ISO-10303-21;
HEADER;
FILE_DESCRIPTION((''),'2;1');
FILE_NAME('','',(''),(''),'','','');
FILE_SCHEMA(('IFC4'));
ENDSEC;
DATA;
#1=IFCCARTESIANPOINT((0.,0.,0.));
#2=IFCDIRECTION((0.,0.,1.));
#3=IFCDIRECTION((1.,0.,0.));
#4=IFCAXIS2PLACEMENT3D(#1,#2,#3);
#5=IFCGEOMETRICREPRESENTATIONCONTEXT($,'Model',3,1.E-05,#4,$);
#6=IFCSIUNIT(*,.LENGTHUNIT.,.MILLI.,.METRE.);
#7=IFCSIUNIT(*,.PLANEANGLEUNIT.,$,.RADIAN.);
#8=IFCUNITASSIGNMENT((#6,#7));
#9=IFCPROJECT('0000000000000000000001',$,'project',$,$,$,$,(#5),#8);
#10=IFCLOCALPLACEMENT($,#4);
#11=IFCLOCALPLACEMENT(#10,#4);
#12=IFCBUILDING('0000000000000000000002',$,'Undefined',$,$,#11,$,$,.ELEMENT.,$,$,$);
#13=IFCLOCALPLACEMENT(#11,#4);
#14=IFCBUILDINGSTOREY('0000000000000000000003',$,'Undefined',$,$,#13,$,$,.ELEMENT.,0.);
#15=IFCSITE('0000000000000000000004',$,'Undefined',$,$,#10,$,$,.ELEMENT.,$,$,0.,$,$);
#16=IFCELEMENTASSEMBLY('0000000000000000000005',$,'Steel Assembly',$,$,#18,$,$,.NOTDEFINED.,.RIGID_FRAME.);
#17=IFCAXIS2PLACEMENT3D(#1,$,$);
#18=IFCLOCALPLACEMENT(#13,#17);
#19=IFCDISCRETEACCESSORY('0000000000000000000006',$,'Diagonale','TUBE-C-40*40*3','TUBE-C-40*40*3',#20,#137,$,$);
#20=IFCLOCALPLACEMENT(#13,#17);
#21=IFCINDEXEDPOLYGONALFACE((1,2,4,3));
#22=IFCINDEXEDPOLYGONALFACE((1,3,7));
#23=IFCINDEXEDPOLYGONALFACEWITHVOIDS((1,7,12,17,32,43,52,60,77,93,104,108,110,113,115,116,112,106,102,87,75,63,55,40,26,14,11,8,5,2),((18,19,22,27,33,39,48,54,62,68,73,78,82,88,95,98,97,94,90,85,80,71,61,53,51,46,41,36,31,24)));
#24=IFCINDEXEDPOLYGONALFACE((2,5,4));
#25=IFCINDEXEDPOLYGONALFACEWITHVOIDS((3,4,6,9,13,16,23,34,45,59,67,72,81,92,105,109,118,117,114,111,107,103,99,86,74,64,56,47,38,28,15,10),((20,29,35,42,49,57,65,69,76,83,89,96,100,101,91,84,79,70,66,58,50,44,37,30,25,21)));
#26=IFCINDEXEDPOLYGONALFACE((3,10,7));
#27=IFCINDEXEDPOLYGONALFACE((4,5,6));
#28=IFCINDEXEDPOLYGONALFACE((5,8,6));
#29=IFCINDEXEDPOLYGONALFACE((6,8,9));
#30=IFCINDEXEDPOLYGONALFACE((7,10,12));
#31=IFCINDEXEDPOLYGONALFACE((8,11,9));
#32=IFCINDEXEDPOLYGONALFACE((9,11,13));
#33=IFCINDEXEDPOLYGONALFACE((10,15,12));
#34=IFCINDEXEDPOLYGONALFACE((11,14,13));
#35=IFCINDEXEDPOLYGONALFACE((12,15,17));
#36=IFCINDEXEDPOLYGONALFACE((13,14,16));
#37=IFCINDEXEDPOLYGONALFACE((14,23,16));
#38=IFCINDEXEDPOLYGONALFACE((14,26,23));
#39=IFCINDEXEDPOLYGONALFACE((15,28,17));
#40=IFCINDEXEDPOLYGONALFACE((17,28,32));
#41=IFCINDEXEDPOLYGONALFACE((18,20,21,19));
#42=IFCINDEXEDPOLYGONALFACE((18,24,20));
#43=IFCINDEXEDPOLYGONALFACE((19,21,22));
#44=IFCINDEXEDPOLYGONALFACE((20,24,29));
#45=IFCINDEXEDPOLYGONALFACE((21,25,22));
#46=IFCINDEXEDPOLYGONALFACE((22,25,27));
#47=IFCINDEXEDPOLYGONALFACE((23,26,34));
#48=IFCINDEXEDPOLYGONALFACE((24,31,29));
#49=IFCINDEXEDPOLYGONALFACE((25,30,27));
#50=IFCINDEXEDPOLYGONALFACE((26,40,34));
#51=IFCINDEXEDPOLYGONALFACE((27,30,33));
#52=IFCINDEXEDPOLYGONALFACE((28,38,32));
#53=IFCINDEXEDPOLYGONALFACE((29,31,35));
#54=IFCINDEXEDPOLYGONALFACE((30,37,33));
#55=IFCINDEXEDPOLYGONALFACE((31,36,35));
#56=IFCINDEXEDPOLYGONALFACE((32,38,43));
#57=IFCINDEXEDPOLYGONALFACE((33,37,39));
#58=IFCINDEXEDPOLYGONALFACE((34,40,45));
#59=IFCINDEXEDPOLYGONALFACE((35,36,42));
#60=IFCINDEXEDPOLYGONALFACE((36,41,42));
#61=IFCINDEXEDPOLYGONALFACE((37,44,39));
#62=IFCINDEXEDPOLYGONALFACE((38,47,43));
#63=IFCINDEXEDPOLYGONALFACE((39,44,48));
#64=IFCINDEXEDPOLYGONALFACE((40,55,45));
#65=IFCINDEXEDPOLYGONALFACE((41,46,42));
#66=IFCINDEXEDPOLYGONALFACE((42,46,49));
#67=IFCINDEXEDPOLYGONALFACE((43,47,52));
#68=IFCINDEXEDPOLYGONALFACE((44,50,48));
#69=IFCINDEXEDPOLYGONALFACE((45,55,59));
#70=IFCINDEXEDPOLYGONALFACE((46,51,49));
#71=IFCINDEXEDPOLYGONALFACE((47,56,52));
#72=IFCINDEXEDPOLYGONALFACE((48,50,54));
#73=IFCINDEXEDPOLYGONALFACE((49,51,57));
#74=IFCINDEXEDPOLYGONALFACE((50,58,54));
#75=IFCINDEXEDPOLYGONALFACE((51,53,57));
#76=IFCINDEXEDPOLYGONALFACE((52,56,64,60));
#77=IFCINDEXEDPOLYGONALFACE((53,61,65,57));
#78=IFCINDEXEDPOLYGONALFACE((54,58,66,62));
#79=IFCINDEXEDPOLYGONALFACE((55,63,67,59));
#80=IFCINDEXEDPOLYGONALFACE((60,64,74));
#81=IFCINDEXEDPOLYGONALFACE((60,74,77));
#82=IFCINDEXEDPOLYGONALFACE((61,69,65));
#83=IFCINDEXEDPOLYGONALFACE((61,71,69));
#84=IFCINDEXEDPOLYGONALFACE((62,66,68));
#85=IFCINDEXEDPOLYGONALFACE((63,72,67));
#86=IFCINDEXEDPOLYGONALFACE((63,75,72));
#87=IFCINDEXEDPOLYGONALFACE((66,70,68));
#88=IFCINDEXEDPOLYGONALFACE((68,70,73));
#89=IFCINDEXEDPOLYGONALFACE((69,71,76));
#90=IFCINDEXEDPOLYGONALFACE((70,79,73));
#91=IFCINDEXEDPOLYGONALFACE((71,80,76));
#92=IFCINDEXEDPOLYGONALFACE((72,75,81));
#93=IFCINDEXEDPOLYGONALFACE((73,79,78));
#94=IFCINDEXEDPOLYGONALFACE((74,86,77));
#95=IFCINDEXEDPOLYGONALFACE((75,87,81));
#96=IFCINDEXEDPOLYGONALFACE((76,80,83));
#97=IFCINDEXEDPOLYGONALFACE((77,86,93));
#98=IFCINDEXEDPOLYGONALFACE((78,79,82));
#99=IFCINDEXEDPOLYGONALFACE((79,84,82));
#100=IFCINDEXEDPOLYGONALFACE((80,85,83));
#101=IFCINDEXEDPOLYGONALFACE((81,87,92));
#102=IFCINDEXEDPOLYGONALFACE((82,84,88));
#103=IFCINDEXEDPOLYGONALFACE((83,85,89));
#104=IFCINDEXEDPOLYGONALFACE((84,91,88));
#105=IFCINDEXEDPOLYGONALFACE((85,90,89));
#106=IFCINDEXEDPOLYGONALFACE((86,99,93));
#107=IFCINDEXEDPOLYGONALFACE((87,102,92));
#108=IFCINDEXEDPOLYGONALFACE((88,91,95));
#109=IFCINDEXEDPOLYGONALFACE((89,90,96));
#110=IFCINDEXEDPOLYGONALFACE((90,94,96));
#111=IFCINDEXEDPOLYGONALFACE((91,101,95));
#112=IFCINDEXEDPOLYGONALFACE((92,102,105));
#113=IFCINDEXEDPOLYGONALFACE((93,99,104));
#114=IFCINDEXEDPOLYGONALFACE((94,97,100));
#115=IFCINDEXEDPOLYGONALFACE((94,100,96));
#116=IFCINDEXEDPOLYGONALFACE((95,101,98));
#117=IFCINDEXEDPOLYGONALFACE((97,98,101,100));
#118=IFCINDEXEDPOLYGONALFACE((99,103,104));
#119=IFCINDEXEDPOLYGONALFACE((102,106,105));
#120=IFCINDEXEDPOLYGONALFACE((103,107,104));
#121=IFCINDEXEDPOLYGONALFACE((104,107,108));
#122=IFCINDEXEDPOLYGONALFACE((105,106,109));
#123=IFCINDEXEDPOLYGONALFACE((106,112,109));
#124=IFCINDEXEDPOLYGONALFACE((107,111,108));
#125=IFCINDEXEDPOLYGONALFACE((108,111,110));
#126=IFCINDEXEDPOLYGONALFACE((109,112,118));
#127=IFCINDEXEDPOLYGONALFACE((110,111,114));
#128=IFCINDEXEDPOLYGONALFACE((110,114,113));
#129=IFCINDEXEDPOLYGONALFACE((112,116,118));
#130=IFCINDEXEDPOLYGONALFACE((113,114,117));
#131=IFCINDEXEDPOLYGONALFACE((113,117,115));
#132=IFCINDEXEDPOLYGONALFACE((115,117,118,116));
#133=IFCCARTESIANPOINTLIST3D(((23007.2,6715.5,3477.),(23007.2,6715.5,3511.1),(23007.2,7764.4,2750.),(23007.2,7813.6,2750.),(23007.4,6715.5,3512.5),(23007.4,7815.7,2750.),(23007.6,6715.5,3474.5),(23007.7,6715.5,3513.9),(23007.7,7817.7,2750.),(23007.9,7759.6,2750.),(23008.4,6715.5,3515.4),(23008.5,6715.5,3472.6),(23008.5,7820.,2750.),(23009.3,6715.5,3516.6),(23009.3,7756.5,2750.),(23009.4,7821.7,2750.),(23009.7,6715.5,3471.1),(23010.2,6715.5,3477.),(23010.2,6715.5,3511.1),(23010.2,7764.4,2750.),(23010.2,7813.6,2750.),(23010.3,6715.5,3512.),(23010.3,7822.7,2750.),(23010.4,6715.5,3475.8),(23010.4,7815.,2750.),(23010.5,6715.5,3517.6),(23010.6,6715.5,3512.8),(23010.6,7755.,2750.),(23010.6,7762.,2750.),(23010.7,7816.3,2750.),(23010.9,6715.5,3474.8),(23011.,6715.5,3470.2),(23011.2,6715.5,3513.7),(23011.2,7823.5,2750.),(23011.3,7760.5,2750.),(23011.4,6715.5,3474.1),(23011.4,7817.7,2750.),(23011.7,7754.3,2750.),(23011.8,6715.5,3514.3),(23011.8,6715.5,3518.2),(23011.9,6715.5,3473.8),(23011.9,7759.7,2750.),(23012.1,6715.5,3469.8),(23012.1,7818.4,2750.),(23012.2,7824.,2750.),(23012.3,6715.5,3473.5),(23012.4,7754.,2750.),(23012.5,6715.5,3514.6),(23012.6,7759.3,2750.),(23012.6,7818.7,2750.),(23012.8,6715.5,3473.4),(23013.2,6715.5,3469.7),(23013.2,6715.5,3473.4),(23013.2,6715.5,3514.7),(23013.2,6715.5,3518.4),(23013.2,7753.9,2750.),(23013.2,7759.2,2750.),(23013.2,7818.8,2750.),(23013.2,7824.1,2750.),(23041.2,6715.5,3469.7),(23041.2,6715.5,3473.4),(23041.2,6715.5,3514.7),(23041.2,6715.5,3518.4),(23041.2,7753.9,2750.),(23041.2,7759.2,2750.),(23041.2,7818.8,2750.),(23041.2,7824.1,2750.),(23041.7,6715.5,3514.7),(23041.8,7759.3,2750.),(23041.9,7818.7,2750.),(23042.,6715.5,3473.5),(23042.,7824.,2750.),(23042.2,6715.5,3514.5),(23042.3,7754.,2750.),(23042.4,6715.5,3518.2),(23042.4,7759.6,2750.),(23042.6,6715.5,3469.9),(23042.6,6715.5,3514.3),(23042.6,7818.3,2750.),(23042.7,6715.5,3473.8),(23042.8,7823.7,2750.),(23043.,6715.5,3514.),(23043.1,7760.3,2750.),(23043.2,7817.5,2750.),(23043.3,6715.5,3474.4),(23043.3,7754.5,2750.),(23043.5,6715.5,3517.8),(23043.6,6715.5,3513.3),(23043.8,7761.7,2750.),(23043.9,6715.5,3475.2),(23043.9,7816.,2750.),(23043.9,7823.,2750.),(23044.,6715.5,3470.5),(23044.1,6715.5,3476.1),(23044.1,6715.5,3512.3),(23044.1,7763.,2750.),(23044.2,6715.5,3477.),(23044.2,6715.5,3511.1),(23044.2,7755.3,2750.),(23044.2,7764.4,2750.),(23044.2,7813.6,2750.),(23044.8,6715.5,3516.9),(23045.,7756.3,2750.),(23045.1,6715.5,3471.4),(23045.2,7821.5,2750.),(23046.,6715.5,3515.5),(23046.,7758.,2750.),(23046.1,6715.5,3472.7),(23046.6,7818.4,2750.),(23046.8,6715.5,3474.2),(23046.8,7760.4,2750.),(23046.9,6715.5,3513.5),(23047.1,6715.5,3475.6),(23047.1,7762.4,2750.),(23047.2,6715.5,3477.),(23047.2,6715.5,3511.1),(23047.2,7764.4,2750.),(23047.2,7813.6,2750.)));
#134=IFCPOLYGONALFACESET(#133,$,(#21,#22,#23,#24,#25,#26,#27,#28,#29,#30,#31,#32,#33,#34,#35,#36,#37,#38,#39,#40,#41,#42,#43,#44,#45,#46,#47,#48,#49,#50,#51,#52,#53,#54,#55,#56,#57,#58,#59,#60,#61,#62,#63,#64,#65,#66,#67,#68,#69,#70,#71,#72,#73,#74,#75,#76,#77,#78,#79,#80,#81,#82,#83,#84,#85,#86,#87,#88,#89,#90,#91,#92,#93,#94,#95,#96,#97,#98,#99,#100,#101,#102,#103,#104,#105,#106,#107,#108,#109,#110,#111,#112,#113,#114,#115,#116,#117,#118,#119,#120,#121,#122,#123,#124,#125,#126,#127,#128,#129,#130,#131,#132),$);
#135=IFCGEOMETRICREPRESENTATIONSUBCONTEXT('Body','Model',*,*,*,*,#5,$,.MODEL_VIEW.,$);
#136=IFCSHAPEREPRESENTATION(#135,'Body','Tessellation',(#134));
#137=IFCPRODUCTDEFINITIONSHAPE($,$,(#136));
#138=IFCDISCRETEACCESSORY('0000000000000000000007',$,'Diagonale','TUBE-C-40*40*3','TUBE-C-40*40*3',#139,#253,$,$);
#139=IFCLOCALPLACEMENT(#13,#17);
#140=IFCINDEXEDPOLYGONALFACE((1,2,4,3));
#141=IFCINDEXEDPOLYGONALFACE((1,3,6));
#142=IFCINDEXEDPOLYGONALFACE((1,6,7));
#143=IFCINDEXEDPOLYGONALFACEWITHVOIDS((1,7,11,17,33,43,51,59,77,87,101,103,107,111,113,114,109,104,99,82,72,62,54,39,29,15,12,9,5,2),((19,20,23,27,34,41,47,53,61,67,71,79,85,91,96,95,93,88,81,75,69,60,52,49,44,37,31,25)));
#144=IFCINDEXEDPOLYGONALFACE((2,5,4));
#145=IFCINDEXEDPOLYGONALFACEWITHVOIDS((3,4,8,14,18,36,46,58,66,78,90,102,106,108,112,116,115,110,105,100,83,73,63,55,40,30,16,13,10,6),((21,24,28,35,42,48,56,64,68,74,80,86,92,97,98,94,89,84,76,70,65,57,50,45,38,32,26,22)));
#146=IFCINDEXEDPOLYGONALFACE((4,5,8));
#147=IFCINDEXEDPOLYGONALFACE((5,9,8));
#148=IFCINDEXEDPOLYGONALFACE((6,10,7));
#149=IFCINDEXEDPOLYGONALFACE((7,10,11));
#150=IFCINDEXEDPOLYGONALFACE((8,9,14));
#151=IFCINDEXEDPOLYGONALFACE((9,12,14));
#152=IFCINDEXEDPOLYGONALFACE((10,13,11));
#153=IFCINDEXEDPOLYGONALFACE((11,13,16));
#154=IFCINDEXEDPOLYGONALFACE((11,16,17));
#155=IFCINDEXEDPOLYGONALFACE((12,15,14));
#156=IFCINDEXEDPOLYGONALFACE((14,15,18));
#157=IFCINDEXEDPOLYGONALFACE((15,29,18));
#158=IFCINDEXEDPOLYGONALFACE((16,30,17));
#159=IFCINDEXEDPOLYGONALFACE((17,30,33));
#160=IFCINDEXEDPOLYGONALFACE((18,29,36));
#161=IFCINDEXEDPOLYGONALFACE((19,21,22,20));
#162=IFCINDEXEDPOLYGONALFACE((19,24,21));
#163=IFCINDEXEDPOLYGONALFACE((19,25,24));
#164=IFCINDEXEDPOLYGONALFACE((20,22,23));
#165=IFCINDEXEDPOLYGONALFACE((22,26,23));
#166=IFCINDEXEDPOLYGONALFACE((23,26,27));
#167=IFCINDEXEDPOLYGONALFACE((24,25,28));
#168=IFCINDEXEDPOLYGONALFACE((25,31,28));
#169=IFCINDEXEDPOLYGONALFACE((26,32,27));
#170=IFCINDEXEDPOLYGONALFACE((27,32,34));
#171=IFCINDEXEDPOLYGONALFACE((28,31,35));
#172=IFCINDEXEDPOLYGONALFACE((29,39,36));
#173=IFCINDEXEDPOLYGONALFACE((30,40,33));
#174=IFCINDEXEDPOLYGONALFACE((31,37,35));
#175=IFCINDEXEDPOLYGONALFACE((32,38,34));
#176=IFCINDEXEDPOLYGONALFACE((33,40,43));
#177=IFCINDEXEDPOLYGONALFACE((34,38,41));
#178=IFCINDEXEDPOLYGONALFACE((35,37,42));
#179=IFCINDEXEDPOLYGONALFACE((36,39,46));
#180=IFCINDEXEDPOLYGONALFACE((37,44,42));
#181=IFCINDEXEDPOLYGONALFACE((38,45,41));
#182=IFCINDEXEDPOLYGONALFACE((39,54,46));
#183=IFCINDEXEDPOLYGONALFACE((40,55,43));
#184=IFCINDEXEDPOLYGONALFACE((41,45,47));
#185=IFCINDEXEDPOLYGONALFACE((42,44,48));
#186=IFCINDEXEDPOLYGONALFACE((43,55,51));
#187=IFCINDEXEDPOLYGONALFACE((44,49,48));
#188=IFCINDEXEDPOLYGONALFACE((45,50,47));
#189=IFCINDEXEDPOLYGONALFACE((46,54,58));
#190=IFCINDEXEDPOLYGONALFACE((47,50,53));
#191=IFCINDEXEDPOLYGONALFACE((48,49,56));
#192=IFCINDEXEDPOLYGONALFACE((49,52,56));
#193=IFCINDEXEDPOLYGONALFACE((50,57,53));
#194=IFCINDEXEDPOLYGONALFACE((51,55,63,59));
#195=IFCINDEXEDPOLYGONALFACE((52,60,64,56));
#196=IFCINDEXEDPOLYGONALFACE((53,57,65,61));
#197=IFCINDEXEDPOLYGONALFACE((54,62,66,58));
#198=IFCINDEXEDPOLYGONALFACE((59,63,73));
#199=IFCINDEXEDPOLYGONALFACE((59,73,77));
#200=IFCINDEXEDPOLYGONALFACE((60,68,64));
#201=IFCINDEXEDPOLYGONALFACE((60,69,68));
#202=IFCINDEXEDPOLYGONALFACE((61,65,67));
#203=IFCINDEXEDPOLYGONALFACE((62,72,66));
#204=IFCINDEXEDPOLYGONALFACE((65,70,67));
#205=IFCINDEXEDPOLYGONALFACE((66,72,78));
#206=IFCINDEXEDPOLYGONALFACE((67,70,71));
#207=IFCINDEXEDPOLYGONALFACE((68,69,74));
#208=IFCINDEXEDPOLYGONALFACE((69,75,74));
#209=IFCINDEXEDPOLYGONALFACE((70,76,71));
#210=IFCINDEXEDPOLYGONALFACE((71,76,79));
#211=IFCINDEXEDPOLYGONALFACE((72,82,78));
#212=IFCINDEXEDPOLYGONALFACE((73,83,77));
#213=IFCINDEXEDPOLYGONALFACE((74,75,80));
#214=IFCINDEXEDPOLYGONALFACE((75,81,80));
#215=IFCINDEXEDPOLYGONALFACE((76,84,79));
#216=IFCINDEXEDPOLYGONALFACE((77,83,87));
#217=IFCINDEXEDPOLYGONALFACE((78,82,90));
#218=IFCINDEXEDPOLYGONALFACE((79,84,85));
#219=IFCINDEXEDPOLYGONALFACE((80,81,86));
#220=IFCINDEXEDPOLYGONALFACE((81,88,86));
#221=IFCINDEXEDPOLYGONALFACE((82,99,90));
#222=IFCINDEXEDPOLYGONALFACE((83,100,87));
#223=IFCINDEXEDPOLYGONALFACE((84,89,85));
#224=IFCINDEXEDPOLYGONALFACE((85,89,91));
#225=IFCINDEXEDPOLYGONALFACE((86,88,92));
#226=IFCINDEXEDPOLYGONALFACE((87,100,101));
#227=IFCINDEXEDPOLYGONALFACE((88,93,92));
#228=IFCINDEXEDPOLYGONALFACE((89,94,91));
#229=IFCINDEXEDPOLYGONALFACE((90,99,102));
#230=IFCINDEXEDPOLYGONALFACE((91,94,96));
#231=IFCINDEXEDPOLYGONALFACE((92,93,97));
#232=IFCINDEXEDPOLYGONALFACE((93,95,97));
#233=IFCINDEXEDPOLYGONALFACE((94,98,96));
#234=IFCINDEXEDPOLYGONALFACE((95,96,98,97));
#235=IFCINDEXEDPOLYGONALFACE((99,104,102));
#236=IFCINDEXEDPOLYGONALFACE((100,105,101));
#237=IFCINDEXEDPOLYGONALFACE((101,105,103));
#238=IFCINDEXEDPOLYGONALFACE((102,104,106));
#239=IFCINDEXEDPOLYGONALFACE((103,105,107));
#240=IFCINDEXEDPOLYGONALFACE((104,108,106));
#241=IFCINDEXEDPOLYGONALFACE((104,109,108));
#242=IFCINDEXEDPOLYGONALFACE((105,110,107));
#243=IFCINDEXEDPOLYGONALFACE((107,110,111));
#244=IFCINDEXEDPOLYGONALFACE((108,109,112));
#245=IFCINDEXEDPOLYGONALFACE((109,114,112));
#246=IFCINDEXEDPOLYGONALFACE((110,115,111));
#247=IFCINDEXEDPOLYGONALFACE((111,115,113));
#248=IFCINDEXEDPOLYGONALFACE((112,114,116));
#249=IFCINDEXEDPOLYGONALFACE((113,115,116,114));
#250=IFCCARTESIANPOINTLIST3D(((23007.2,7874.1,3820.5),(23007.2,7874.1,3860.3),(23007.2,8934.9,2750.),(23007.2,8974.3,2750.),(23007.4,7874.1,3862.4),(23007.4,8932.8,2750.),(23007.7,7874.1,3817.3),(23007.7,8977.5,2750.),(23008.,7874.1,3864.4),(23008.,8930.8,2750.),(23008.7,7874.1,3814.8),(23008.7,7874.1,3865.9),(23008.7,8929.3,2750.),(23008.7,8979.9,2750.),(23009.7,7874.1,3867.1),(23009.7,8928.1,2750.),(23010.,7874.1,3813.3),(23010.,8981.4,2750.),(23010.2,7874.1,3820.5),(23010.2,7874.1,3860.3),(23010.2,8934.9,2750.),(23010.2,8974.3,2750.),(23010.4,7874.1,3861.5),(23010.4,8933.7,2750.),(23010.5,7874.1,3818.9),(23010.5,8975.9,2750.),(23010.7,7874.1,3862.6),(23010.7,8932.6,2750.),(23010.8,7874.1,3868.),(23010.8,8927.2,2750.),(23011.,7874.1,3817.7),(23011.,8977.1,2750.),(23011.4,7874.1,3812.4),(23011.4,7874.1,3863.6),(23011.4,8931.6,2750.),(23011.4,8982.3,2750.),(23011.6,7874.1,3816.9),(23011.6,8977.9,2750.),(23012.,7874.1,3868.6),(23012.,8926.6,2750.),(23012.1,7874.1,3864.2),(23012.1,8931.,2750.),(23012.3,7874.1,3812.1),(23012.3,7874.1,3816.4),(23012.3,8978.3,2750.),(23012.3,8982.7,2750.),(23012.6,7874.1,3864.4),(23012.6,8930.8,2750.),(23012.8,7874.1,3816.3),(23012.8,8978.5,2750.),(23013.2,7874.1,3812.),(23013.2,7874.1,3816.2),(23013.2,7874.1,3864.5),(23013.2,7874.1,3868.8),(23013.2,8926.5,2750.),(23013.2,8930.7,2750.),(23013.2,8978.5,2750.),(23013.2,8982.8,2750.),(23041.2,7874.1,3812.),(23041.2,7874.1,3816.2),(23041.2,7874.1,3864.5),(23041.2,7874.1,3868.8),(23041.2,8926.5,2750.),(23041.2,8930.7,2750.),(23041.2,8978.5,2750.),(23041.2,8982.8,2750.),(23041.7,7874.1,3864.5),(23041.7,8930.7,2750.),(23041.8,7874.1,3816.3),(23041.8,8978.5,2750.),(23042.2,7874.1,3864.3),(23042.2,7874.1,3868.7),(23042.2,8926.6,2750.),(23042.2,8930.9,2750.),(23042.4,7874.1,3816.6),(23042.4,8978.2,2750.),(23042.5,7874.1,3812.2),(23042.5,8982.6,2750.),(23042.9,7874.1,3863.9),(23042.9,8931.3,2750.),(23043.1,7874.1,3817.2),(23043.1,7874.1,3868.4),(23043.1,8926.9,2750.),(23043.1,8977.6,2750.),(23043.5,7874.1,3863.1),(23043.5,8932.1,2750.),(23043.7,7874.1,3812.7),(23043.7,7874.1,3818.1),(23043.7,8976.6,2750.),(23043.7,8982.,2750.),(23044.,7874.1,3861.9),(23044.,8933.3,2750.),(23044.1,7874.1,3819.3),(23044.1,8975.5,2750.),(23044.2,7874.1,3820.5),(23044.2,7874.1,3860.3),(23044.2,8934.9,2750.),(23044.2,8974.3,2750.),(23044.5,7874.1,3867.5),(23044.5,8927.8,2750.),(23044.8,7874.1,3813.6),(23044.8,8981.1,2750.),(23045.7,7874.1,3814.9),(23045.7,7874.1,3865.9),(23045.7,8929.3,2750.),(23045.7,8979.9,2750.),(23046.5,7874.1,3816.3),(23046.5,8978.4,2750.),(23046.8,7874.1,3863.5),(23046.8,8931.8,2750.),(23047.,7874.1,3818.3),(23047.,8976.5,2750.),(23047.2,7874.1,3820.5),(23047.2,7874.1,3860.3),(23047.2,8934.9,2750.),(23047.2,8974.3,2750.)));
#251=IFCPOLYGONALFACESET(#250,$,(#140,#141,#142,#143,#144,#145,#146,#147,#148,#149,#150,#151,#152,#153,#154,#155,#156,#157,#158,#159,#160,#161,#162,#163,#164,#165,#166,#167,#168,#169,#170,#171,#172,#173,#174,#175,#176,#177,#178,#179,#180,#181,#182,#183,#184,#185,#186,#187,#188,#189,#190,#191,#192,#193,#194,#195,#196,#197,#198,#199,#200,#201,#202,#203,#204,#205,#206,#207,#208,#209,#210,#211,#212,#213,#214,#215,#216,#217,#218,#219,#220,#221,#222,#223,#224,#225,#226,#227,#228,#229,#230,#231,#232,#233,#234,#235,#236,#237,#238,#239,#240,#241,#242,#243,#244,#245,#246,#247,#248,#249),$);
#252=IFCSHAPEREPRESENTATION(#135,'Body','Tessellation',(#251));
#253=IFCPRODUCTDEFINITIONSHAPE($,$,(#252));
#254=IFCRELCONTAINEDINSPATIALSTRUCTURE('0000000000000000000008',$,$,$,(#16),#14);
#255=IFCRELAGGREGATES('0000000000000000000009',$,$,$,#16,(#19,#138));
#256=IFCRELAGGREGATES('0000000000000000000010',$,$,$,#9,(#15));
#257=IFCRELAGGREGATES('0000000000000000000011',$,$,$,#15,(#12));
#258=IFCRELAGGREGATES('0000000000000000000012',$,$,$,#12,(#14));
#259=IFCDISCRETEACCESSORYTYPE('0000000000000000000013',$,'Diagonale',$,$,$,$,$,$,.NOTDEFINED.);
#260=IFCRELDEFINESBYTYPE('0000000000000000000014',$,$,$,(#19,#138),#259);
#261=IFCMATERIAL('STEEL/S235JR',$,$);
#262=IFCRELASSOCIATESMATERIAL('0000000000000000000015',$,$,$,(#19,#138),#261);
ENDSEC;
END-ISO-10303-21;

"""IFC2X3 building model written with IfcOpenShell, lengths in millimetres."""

from ifc_helpers import new_model, si_unit, frame, origin_with_axes, origin_2d_with_axis, place, context, subcontext, project, spatial, hollow_rectangle, extrude, clip, halfspace, material, type_object, element, aggregate, save


model = new_model("IFC2X3")

# Units and contexts
model_context = context("Model", 3, precision=1e-05, world=origin_with_axes())
body_context = subcontext(model_context, "Body", "Model", "MODEL_VIEW")
ifc_project = project(units=[si_unit("LENGTHUNIT", "METRE", prefix="MILLI"), si_unit("PLANEANGLEUNIT", "RADIAN")], contexts=[model_context])

# Site, building, storey
site_placement = place(None, origin_with_axes())
site = spatial("IfcSite", under=ifc_project, at=site_placement, Name="Undefined", CompositionType="ELEMENT", RefElevation=0.0)
building_placement = place(site_placement, origin_with_axes())
building = spatial("IfcBuilding", under=site, at=building_placement, Name="Undefined", CompositionType="ELEMENT")
storey_placement = place(building_placement, origin_with_axes())
storey = spatial("IfcBuildingStorey", under=building, at=storey_placement, Name="Undefined", CompositionType="ELEMENT", Elevation=0.0)

# Element assembly, discrete accessories
ifc_material_1 = material(Name="STEEL/S235JR")
assembly_1_placement = place(storey_placement, origin_with_axes())
assembly_1 = element("IfcElementAssembly", 1, at=assembly_1_placement, inside=storey, Name="Steel Assembly", AssemblyPlace="NOTDEFINED", PredefinedType="RIGID_FRAME")
discrete_accessory_type_1 = type_object("IfcDiscreteAccessoryType", Name="Diagonale")
discrete_accessory_1_placement = place(assembly_1_placement, frame((23027.2, 7812.7, 2733.6), z_axis=(0.0, 0.569631, 0.821901), x_axis=(0.0, -0.821901, 0.569631)))
discrete_accessory_1 = element("IfcDiscreteAccessory", 2, at=discrete_accessory_1_placement, type_object=discrete_accessory_type_1, material=ifc_material_1, Name="Diagonale", Description="TUBE-C-40*40*3", ObjectType="TUBE-C-40*40*3", context=body_context, shape_type="Clipping", body=[
    clip(clip(extrude(hollow_rectangle(XDim=40.0, YDim=40.0, WallThickness=3.0, InnerFilletRadius=3.0, OuterFilletRadius=6.0, at=origin_2d_with_axis()), frame((1378.2, 0.0, 0.0), z_axis=(-1.0, 0.0, 0.0), x_axis=(0.0, -1.0, 0.0)), (0.0, 0.0, 1.0), 1392.5), halfspace(frame((1298.5, 0.0, -52.7), z_axis=(0.821901, 0.0, -0.569631), x_axis=(0.569631, 0.0, 0.821901)), False)), halfspace(frame((80.9, 0.0, -36.0), z_axis=(0.569631, 0.0, 0.821901), x_axis=(-0.821901, 0.0, 0.569631)), True)),
])
discrete_accessory_2_placement = place(assembly_1_placement, frame((23027.2, 8968.6, 2735.9), z_axis=(0.0, 0.710321, 0.703878), x_axis=(0.0, -0.703878, 0.710321)))
discrete_accessory_2 = element("IfcDiscreteAccessory", 3, at=discrete_accessory_2_placement, type_object=discrete_accessory_type_1, material=ifc_material_1, Name="Diagonale", Description="TUBE-C-40*40*3", ObjectType="TUBE-C-40*40*3", context=body_context, shape_type="Clipping", body=[
    clip(clip(extrude(hollow_rectangle(XDim=40.0, YDim=40.0, WallThickness=3.0, InnerFilletRadius=3.0, OuterFilletRadius=6.0, at=origin_2d_with_axis()), frame((1595.3, 0.0, 0.0), z_axis=(-1.0, 0.0, 0.0), x_axis=(0.0, -1.0, 0.0)), (0.0, 0.0, 1.0), 1615.9), halfspace(frame((1512.1, 0.0, -42.4), z_axis=(0.703878, 0.0, -0.710321), x_axis=(0.710321, 0.0, 0.703878)), False)), halfspace(frame((21.0, 0.0, -1.2), z_axis=(-0.710321, 0.0, -0.703878), x_axis=(0.703878, 0.0, -0.710321)), False)),
])
aggregate(assembly_1, [discrete_accessory_1, discrete_accessory_2])

save(model, "model.ifc")
